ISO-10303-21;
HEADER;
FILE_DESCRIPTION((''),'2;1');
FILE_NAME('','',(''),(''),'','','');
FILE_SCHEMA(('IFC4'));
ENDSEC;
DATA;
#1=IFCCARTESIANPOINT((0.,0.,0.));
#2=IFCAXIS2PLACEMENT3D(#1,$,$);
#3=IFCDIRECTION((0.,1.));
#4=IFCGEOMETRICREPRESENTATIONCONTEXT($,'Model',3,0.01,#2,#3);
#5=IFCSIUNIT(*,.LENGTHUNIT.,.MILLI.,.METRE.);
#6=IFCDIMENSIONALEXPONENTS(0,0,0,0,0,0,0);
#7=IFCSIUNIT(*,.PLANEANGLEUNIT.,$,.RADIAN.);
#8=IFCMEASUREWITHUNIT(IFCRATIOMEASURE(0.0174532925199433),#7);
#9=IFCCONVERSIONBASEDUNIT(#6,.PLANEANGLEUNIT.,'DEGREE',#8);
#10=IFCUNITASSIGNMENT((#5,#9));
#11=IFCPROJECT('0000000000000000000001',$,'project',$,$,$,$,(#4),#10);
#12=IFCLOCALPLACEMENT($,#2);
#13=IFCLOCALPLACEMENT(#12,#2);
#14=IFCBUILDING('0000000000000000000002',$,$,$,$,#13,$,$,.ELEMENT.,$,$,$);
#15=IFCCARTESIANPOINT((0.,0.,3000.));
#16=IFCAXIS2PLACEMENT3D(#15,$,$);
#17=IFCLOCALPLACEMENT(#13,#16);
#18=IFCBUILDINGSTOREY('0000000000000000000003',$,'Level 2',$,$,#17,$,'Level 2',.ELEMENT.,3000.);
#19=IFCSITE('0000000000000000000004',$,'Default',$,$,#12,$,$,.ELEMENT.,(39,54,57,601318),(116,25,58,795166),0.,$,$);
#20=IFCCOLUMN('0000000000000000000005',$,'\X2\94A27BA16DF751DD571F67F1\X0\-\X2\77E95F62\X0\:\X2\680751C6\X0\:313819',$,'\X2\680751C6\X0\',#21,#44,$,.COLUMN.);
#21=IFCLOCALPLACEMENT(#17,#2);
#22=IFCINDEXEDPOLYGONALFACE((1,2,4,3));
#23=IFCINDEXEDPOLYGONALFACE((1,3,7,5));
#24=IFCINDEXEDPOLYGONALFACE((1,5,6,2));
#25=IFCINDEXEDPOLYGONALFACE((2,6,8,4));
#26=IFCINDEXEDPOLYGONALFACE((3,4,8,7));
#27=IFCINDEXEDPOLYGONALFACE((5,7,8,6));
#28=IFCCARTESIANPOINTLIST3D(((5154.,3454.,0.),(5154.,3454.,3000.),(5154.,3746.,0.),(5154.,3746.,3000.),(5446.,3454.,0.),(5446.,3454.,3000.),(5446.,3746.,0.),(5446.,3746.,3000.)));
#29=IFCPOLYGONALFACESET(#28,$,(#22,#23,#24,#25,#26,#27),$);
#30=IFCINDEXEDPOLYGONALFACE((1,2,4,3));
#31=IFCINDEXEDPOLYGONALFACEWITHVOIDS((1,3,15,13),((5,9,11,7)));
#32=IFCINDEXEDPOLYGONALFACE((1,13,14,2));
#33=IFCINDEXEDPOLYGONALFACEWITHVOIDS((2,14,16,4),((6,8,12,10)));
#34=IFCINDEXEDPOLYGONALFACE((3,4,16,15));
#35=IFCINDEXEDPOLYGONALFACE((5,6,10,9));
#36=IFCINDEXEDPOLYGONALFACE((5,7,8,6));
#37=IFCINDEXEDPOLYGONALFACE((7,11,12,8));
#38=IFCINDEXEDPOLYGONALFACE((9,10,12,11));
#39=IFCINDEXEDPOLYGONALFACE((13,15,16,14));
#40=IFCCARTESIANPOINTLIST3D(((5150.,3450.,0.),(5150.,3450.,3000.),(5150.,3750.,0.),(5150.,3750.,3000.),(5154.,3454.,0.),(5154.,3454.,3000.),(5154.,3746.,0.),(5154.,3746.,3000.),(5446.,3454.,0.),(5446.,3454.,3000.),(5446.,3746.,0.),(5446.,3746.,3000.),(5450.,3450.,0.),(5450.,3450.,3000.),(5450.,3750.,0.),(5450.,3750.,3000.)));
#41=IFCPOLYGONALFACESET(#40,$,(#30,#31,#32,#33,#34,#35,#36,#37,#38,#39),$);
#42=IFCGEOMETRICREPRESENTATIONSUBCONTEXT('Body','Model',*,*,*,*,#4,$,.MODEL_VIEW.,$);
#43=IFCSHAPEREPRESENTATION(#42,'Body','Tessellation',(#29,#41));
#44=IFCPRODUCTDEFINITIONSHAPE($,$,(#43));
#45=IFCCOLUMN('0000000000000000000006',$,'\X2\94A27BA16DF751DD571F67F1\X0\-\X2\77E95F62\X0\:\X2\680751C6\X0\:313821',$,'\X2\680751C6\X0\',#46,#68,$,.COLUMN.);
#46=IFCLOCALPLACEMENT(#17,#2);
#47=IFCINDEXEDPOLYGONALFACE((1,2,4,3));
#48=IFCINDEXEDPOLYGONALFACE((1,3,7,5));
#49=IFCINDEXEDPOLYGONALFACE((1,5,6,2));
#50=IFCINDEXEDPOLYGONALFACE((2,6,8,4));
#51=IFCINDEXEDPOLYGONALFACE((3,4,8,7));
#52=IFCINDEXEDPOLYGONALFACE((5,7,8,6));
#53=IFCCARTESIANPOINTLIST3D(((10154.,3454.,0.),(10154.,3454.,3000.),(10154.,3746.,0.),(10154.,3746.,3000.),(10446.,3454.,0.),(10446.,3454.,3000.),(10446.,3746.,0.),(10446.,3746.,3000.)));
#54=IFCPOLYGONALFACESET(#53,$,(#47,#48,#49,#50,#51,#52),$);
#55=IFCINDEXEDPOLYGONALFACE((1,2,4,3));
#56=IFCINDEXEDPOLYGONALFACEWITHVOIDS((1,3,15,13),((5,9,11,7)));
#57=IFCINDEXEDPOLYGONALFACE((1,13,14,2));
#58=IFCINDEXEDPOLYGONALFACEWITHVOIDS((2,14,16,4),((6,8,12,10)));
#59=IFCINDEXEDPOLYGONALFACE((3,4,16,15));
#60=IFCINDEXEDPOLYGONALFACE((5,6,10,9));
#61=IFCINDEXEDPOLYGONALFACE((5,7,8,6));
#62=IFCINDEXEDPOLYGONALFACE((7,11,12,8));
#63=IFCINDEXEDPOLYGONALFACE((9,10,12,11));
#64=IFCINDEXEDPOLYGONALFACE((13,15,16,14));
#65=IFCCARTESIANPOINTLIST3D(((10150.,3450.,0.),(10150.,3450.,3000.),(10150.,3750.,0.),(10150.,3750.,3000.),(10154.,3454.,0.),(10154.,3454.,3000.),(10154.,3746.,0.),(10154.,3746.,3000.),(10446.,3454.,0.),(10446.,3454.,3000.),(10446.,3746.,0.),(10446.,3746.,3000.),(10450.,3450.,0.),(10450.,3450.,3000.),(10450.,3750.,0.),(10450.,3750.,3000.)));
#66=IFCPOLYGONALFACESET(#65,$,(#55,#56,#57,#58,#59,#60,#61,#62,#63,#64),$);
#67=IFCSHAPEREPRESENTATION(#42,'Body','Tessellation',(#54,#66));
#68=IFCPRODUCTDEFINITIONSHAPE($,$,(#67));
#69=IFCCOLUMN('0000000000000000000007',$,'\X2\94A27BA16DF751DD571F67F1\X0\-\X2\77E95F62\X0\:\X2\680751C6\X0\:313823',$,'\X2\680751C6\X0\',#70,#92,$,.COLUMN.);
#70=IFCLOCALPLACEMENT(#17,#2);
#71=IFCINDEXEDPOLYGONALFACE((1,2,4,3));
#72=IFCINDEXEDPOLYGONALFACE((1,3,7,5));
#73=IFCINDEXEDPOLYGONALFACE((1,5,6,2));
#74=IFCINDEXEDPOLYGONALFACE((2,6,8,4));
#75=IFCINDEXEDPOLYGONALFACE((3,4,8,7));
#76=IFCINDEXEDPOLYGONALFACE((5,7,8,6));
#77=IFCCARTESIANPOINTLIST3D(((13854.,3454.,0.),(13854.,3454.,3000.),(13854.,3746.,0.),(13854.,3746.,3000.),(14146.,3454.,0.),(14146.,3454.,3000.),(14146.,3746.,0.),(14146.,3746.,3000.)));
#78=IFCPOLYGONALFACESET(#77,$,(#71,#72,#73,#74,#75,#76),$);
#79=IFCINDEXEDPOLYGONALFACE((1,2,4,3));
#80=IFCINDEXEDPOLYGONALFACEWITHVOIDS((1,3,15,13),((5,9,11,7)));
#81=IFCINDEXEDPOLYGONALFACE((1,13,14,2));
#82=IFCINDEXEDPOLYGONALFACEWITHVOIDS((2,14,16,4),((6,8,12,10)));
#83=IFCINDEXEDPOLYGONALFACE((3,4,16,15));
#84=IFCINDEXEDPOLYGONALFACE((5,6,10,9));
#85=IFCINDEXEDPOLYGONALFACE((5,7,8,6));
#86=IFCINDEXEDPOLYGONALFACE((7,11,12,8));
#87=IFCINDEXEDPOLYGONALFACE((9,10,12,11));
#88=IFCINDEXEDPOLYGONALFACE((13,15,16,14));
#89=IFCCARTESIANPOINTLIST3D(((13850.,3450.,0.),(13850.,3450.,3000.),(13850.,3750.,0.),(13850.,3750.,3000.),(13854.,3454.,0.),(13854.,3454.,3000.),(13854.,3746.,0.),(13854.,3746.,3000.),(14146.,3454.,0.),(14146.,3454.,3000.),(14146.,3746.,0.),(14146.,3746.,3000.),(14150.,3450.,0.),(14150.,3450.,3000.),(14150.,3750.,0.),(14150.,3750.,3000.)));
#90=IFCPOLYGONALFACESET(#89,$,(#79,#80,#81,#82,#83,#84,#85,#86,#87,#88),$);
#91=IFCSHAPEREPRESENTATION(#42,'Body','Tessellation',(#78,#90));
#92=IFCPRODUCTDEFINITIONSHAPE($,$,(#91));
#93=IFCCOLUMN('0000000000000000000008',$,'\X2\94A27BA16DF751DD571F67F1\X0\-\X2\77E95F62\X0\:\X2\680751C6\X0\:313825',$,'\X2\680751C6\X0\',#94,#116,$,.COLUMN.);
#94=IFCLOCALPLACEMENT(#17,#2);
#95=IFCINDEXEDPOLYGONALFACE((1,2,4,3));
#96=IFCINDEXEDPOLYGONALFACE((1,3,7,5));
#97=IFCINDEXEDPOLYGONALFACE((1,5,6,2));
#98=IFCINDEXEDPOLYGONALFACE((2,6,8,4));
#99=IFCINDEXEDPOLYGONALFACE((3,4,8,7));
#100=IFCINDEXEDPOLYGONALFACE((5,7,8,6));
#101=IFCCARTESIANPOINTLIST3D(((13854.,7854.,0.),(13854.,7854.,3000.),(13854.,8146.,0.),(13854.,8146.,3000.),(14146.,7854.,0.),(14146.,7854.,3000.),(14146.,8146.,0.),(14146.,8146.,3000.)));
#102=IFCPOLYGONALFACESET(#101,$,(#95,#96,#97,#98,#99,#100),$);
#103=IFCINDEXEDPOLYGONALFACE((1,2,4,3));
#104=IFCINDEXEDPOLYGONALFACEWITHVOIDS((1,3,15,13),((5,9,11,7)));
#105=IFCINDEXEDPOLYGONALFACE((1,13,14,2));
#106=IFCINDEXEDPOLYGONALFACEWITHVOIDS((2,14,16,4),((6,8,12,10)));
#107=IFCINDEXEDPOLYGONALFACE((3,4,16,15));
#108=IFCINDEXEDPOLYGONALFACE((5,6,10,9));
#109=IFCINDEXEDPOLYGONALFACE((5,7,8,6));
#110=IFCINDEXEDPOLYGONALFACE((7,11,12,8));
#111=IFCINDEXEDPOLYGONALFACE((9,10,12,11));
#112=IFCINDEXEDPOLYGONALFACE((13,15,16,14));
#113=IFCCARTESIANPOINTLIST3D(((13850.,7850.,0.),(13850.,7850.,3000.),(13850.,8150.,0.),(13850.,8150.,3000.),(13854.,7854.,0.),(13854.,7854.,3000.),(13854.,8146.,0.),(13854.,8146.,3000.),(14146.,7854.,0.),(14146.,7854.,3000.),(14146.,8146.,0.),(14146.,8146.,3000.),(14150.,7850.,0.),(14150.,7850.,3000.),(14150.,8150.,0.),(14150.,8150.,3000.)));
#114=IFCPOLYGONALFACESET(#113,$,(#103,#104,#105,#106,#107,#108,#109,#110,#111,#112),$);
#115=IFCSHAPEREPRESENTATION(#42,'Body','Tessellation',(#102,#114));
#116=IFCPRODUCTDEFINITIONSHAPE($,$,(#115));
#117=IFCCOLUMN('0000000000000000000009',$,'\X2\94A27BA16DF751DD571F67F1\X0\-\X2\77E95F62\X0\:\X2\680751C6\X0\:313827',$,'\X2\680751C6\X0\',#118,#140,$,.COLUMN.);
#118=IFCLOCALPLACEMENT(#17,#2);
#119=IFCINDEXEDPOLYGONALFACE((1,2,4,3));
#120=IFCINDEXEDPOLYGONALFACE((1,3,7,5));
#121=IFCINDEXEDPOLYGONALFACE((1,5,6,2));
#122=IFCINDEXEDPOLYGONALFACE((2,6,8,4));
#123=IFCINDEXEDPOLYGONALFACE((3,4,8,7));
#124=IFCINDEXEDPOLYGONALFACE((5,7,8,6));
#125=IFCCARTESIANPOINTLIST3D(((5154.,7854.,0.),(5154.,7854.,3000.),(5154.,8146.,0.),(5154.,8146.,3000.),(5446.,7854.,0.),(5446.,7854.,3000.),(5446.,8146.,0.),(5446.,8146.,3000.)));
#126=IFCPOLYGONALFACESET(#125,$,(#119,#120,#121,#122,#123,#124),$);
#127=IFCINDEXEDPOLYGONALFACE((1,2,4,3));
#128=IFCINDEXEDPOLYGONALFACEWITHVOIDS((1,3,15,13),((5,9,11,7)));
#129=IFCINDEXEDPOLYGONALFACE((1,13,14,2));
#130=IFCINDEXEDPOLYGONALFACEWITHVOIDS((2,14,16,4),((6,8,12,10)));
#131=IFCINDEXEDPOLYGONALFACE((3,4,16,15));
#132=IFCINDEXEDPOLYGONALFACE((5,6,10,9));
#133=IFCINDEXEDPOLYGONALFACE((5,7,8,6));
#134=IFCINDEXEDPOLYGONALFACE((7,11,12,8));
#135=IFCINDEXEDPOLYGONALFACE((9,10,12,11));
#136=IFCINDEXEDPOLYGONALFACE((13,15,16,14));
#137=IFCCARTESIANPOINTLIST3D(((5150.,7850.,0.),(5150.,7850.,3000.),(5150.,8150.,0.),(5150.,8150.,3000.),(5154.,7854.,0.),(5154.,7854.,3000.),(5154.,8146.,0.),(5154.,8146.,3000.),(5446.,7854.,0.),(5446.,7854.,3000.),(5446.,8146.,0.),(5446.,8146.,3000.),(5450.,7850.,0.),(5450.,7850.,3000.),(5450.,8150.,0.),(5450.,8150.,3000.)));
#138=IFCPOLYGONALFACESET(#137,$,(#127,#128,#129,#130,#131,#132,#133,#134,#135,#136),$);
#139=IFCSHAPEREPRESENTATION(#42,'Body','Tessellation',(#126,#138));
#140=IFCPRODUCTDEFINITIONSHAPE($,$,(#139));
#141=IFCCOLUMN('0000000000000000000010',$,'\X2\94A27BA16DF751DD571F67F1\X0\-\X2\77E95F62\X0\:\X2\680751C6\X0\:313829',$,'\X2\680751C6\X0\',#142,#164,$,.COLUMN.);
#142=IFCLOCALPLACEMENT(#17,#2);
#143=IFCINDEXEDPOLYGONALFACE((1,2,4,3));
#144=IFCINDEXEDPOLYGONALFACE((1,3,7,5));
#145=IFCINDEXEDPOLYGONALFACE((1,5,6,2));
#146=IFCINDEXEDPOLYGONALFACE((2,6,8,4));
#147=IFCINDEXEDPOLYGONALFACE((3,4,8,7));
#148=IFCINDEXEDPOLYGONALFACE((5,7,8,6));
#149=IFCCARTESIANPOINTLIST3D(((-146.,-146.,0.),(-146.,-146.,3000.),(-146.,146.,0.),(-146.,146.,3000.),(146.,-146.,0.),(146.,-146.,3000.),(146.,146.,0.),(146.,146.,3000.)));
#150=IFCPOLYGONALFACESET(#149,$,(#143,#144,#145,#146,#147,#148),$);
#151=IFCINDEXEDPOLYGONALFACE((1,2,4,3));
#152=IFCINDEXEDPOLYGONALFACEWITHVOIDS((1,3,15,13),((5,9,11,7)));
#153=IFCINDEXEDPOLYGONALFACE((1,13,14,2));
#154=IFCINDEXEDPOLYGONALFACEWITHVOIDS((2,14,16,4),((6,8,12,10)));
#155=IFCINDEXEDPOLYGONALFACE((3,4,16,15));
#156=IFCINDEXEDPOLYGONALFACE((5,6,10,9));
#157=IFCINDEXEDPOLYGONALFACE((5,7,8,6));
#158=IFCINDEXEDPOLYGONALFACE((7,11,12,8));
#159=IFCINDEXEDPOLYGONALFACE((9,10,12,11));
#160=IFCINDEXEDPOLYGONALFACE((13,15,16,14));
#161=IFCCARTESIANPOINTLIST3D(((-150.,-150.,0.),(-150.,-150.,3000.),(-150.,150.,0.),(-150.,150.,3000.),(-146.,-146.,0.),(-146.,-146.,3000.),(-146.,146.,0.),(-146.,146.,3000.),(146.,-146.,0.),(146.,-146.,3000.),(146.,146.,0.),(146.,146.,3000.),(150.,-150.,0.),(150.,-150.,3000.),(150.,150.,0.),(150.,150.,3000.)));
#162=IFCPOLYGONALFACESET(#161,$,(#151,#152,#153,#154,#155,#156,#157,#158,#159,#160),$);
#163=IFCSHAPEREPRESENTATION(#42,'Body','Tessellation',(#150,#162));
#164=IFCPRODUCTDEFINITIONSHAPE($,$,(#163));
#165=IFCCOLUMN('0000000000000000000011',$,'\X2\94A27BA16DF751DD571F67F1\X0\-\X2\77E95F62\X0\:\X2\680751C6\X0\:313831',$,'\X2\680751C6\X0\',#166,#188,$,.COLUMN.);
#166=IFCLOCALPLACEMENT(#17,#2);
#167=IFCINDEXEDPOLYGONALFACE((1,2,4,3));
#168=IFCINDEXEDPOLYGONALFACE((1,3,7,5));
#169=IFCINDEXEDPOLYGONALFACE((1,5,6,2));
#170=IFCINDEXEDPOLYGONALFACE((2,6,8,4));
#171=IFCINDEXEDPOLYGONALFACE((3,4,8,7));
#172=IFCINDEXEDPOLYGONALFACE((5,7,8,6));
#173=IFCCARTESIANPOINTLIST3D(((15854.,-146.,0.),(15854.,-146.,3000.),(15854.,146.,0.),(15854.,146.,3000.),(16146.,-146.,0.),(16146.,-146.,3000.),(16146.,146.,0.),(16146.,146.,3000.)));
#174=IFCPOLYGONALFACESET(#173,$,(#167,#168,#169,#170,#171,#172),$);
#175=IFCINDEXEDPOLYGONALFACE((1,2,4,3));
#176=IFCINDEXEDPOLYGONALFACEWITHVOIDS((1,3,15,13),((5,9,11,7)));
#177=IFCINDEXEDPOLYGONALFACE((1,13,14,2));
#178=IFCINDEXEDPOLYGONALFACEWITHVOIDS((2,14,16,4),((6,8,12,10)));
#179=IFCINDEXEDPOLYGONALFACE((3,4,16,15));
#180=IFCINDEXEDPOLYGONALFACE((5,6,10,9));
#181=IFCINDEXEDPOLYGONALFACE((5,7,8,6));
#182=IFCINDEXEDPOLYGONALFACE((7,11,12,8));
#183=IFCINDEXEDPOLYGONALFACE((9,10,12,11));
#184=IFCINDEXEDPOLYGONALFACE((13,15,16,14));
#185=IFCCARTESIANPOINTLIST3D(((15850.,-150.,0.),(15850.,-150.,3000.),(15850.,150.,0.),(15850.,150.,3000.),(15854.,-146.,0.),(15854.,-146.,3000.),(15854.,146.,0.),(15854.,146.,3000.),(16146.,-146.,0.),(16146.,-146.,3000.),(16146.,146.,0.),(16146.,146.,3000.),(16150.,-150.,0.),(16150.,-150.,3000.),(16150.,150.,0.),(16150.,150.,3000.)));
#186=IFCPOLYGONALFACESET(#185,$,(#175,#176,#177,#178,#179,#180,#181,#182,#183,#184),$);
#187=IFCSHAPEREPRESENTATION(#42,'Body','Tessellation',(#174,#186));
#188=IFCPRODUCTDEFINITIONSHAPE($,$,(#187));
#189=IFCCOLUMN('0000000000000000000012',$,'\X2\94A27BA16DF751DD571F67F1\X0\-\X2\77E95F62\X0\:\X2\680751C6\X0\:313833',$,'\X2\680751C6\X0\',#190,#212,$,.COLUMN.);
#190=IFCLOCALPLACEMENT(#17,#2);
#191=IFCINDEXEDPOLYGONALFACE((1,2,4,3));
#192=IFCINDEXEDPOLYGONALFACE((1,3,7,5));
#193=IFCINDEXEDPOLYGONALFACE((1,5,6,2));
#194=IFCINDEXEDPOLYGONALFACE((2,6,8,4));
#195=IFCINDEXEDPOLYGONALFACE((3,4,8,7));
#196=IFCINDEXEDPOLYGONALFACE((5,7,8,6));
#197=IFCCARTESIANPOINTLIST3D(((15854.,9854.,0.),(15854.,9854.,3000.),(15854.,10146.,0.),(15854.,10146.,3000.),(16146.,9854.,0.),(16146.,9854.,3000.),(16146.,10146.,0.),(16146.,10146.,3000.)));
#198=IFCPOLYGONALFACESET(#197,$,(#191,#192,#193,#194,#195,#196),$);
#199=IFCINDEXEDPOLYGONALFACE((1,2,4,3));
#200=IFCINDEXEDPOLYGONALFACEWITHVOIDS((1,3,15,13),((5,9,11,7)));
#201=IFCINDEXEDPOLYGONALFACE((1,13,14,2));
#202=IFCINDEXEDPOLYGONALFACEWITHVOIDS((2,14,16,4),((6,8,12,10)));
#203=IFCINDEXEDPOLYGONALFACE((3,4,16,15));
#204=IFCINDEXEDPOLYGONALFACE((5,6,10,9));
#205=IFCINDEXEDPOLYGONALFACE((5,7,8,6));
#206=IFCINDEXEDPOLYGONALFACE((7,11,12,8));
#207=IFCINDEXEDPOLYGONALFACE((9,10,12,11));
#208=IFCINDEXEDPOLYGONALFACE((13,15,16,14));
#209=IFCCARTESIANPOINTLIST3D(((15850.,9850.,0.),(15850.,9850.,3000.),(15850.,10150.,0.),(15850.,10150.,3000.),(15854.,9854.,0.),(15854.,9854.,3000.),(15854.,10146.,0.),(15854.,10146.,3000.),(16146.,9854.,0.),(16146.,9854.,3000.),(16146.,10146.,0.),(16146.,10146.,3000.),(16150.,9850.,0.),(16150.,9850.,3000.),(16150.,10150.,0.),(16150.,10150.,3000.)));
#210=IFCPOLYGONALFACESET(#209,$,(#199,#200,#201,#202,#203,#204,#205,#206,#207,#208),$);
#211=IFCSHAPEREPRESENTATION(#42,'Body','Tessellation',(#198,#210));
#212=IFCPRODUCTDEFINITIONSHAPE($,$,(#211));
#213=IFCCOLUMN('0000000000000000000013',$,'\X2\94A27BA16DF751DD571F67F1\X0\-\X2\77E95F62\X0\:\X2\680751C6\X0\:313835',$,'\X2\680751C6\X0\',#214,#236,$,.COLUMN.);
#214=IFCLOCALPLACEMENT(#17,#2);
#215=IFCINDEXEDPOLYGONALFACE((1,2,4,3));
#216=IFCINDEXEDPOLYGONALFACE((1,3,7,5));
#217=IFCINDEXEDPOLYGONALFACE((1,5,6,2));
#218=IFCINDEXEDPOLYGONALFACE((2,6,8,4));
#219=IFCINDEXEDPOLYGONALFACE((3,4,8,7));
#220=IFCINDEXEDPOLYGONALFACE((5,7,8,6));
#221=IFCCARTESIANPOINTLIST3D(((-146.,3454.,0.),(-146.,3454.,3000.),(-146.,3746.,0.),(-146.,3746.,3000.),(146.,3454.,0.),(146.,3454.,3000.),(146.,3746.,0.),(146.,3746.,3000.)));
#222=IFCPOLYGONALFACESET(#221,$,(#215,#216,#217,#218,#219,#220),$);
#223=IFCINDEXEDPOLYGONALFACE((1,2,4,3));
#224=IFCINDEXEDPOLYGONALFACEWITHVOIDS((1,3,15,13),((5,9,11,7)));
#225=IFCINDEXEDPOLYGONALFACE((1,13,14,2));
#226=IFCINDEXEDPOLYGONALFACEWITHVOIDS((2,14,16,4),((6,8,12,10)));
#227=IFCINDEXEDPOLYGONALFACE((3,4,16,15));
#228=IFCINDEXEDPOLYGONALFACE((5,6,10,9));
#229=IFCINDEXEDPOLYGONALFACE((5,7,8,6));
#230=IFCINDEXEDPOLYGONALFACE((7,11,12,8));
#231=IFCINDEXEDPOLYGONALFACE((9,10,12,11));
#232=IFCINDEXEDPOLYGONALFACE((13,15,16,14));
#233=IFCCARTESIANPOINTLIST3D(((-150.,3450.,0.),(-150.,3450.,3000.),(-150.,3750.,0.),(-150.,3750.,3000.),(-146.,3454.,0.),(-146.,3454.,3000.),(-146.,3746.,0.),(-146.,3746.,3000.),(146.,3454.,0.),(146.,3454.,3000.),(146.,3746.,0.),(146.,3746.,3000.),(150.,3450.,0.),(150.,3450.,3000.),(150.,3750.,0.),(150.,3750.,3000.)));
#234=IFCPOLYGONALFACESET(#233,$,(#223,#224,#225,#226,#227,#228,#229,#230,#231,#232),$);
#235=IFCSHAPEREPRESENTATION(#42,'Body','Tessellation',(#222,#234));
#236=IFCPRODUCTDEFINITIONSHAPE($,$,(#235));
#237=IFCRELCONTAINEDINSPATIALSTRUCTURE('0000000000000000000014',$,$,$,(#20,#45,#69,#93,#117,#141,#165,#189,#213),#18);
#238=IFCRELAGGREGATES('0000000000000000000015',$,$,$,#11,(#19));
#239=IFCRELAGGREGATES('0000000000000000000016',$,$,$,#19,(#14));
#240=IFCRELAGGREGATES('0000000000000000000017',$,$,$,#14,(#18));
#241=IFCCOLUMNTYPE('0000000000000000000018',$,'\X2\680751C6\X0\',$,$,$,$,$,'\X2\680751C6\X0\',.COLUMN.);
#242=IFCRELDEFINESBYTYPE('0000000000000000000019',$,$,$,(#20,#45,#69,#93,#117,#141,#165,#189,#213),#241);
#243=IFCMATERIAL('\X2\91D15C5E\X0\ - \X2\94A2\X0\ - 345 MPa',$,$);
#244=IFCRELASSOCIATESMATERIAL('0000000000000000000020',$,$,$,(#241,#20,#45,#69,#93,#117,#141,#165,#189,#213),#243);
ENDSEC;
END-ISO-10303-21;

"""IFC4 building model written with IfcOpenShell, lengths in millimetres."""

from ifc_helpers import new_model, entity, si_unit, converted_unit, direction, frame, origin, origin_2d_with_axis, place, context, subcontext, project, spatial, polyline, rectangle, outline, extrude, source, transform, mapped, material, type_object, type_shapes, element, save


model = new_model("IFC4")

# Units and contexts
model_context = context("Model", 3, precision=0.01, world=origin(), true_north=direction((0.0, 1.0)))
body_context = subcontext(model_context, "Body", "Model", "MODEL_VIEW")
ifc_project = project(units=[si_unit("LENGTHUNIT", "METRE", prefix="MILLI"), converted_unit("PLANEANGLEUNIT", "DEGREE", entity("IfcRatioMeasure", 0.0174532925199433), si_unit("PLANEANGLEUNIT", "RADIAN"), dimensions=[0, 0, 0, 0, 0, 0, 0])], contexts=[model_context])

# Site, building, storey
site_placement = place(None, origin())
site = spatial("IfcSite", under=ifc_project, at=site_placement, Name="Default", CompositionType="ELEMENT", RefLatitude=(39, 54, 57, 601318), RefLongitude=(116, 25, 58, 795166), RefElevation=0.0)
building_placement = place(site_placement, origin())
building = spatial("IfcBuilding", under=site, at=building_placement, CompositionType="ELEMENT")
storey_placement = place(building_placement, frame((0.0, 0.0, 3000.0)))
storey = spatial("IfcBuildingStorey", under=building, at=storey_placement, Name="Level 2", LongName="Level 2", CompositionType="ELEMENT", Elevation=3000.0)

# Columns
ifc_material = material(Name="金属 - 钢 - 345 MPa")
column_type = type_object("IfcColumnType", Name="标准", ElementType="标准", PredefinedType="COLUMN", material=ifc_material)
shared_shape = source(origin(), body_context, "Body", "SweptSolid", [
    extrude(rectangle(XDim=292.0, YDim=292.0, at=origin_2d_with_axis()), frame((150.0, 150.0, 0.0), z_axis=(0.0, 0.0, 1.0), x_axis=(-1.0, 0.0, 0.0)), (0.0, 0.0, 1.0), 3000.0),
    extrude(outline(polyline([(-150.0, -150.0), (150.0, -150.0), (150.0, 150.0), (-150.0, 150.0), (-150.0, -150.0)]), holes=[polyline([(-146.0, -146.0), (-146.0, 146.0), (146.0, 146.0), (146.0, -146.0), (-146.0, -146.0)])]), frame((150.0, 150.0, 0.0), z_axis=(0.0, 0.0, 1.0), x_axis=(-1.0, 0.0, 0.0)), (0.0, 0.0, 1.0), 3000.0),
])
type_shapes(column_type, [shared_shape])
for number, where, name in (
    (1, (5150.0, 3450.0, 0.0), "钢管混凝土柱-矩形:标准:313819"),
    (2, (10150.0, 3450.0, 0.0), "钢管混凝土柱-矩形:标准:313821"),
    (3, (13850.0, 3450.0, 0.0), "钢管混凝土柱-矩形:标准:313823"),
    (4, (13850.0, 7850.0, 0.0), "钢管混凝土柱-矩形:标准:313825"),
    (5, (5150.0, 7850.0, 0.0), "钢管混凝土柱-矩形:标准:313827"),
    (6, (-150.0, -150.0, 0.0), "钢管混凝土柱-矩形:标准:313829"),
    (7, (15850.0, -150.0, 0.0), "钢管混凝土柱-矩形:标准:313831"),
    (8, (15850.0, 9850.0, 0.0), "钢管混凝土柱-矩形:标准:313833"),
    (9, (-150.0, 3450.0, 0.0), "钢管混凝土柱-矩形:标准:313835"),
):
    element("IfcColumn", number, at=place(storey_placement, frame(where)), inside=storey, type_object=column_type, material=ifc_material, Name=name, ObjectType="标准", PredefinedType="COLUMN", context=body_context, shape_type="MappedRepresentation", body=[
        mapped(shared_shape, transform((0.0, 0.0, 0.0), scale=1.0)),
    ])

save(model, "model.ifc")
